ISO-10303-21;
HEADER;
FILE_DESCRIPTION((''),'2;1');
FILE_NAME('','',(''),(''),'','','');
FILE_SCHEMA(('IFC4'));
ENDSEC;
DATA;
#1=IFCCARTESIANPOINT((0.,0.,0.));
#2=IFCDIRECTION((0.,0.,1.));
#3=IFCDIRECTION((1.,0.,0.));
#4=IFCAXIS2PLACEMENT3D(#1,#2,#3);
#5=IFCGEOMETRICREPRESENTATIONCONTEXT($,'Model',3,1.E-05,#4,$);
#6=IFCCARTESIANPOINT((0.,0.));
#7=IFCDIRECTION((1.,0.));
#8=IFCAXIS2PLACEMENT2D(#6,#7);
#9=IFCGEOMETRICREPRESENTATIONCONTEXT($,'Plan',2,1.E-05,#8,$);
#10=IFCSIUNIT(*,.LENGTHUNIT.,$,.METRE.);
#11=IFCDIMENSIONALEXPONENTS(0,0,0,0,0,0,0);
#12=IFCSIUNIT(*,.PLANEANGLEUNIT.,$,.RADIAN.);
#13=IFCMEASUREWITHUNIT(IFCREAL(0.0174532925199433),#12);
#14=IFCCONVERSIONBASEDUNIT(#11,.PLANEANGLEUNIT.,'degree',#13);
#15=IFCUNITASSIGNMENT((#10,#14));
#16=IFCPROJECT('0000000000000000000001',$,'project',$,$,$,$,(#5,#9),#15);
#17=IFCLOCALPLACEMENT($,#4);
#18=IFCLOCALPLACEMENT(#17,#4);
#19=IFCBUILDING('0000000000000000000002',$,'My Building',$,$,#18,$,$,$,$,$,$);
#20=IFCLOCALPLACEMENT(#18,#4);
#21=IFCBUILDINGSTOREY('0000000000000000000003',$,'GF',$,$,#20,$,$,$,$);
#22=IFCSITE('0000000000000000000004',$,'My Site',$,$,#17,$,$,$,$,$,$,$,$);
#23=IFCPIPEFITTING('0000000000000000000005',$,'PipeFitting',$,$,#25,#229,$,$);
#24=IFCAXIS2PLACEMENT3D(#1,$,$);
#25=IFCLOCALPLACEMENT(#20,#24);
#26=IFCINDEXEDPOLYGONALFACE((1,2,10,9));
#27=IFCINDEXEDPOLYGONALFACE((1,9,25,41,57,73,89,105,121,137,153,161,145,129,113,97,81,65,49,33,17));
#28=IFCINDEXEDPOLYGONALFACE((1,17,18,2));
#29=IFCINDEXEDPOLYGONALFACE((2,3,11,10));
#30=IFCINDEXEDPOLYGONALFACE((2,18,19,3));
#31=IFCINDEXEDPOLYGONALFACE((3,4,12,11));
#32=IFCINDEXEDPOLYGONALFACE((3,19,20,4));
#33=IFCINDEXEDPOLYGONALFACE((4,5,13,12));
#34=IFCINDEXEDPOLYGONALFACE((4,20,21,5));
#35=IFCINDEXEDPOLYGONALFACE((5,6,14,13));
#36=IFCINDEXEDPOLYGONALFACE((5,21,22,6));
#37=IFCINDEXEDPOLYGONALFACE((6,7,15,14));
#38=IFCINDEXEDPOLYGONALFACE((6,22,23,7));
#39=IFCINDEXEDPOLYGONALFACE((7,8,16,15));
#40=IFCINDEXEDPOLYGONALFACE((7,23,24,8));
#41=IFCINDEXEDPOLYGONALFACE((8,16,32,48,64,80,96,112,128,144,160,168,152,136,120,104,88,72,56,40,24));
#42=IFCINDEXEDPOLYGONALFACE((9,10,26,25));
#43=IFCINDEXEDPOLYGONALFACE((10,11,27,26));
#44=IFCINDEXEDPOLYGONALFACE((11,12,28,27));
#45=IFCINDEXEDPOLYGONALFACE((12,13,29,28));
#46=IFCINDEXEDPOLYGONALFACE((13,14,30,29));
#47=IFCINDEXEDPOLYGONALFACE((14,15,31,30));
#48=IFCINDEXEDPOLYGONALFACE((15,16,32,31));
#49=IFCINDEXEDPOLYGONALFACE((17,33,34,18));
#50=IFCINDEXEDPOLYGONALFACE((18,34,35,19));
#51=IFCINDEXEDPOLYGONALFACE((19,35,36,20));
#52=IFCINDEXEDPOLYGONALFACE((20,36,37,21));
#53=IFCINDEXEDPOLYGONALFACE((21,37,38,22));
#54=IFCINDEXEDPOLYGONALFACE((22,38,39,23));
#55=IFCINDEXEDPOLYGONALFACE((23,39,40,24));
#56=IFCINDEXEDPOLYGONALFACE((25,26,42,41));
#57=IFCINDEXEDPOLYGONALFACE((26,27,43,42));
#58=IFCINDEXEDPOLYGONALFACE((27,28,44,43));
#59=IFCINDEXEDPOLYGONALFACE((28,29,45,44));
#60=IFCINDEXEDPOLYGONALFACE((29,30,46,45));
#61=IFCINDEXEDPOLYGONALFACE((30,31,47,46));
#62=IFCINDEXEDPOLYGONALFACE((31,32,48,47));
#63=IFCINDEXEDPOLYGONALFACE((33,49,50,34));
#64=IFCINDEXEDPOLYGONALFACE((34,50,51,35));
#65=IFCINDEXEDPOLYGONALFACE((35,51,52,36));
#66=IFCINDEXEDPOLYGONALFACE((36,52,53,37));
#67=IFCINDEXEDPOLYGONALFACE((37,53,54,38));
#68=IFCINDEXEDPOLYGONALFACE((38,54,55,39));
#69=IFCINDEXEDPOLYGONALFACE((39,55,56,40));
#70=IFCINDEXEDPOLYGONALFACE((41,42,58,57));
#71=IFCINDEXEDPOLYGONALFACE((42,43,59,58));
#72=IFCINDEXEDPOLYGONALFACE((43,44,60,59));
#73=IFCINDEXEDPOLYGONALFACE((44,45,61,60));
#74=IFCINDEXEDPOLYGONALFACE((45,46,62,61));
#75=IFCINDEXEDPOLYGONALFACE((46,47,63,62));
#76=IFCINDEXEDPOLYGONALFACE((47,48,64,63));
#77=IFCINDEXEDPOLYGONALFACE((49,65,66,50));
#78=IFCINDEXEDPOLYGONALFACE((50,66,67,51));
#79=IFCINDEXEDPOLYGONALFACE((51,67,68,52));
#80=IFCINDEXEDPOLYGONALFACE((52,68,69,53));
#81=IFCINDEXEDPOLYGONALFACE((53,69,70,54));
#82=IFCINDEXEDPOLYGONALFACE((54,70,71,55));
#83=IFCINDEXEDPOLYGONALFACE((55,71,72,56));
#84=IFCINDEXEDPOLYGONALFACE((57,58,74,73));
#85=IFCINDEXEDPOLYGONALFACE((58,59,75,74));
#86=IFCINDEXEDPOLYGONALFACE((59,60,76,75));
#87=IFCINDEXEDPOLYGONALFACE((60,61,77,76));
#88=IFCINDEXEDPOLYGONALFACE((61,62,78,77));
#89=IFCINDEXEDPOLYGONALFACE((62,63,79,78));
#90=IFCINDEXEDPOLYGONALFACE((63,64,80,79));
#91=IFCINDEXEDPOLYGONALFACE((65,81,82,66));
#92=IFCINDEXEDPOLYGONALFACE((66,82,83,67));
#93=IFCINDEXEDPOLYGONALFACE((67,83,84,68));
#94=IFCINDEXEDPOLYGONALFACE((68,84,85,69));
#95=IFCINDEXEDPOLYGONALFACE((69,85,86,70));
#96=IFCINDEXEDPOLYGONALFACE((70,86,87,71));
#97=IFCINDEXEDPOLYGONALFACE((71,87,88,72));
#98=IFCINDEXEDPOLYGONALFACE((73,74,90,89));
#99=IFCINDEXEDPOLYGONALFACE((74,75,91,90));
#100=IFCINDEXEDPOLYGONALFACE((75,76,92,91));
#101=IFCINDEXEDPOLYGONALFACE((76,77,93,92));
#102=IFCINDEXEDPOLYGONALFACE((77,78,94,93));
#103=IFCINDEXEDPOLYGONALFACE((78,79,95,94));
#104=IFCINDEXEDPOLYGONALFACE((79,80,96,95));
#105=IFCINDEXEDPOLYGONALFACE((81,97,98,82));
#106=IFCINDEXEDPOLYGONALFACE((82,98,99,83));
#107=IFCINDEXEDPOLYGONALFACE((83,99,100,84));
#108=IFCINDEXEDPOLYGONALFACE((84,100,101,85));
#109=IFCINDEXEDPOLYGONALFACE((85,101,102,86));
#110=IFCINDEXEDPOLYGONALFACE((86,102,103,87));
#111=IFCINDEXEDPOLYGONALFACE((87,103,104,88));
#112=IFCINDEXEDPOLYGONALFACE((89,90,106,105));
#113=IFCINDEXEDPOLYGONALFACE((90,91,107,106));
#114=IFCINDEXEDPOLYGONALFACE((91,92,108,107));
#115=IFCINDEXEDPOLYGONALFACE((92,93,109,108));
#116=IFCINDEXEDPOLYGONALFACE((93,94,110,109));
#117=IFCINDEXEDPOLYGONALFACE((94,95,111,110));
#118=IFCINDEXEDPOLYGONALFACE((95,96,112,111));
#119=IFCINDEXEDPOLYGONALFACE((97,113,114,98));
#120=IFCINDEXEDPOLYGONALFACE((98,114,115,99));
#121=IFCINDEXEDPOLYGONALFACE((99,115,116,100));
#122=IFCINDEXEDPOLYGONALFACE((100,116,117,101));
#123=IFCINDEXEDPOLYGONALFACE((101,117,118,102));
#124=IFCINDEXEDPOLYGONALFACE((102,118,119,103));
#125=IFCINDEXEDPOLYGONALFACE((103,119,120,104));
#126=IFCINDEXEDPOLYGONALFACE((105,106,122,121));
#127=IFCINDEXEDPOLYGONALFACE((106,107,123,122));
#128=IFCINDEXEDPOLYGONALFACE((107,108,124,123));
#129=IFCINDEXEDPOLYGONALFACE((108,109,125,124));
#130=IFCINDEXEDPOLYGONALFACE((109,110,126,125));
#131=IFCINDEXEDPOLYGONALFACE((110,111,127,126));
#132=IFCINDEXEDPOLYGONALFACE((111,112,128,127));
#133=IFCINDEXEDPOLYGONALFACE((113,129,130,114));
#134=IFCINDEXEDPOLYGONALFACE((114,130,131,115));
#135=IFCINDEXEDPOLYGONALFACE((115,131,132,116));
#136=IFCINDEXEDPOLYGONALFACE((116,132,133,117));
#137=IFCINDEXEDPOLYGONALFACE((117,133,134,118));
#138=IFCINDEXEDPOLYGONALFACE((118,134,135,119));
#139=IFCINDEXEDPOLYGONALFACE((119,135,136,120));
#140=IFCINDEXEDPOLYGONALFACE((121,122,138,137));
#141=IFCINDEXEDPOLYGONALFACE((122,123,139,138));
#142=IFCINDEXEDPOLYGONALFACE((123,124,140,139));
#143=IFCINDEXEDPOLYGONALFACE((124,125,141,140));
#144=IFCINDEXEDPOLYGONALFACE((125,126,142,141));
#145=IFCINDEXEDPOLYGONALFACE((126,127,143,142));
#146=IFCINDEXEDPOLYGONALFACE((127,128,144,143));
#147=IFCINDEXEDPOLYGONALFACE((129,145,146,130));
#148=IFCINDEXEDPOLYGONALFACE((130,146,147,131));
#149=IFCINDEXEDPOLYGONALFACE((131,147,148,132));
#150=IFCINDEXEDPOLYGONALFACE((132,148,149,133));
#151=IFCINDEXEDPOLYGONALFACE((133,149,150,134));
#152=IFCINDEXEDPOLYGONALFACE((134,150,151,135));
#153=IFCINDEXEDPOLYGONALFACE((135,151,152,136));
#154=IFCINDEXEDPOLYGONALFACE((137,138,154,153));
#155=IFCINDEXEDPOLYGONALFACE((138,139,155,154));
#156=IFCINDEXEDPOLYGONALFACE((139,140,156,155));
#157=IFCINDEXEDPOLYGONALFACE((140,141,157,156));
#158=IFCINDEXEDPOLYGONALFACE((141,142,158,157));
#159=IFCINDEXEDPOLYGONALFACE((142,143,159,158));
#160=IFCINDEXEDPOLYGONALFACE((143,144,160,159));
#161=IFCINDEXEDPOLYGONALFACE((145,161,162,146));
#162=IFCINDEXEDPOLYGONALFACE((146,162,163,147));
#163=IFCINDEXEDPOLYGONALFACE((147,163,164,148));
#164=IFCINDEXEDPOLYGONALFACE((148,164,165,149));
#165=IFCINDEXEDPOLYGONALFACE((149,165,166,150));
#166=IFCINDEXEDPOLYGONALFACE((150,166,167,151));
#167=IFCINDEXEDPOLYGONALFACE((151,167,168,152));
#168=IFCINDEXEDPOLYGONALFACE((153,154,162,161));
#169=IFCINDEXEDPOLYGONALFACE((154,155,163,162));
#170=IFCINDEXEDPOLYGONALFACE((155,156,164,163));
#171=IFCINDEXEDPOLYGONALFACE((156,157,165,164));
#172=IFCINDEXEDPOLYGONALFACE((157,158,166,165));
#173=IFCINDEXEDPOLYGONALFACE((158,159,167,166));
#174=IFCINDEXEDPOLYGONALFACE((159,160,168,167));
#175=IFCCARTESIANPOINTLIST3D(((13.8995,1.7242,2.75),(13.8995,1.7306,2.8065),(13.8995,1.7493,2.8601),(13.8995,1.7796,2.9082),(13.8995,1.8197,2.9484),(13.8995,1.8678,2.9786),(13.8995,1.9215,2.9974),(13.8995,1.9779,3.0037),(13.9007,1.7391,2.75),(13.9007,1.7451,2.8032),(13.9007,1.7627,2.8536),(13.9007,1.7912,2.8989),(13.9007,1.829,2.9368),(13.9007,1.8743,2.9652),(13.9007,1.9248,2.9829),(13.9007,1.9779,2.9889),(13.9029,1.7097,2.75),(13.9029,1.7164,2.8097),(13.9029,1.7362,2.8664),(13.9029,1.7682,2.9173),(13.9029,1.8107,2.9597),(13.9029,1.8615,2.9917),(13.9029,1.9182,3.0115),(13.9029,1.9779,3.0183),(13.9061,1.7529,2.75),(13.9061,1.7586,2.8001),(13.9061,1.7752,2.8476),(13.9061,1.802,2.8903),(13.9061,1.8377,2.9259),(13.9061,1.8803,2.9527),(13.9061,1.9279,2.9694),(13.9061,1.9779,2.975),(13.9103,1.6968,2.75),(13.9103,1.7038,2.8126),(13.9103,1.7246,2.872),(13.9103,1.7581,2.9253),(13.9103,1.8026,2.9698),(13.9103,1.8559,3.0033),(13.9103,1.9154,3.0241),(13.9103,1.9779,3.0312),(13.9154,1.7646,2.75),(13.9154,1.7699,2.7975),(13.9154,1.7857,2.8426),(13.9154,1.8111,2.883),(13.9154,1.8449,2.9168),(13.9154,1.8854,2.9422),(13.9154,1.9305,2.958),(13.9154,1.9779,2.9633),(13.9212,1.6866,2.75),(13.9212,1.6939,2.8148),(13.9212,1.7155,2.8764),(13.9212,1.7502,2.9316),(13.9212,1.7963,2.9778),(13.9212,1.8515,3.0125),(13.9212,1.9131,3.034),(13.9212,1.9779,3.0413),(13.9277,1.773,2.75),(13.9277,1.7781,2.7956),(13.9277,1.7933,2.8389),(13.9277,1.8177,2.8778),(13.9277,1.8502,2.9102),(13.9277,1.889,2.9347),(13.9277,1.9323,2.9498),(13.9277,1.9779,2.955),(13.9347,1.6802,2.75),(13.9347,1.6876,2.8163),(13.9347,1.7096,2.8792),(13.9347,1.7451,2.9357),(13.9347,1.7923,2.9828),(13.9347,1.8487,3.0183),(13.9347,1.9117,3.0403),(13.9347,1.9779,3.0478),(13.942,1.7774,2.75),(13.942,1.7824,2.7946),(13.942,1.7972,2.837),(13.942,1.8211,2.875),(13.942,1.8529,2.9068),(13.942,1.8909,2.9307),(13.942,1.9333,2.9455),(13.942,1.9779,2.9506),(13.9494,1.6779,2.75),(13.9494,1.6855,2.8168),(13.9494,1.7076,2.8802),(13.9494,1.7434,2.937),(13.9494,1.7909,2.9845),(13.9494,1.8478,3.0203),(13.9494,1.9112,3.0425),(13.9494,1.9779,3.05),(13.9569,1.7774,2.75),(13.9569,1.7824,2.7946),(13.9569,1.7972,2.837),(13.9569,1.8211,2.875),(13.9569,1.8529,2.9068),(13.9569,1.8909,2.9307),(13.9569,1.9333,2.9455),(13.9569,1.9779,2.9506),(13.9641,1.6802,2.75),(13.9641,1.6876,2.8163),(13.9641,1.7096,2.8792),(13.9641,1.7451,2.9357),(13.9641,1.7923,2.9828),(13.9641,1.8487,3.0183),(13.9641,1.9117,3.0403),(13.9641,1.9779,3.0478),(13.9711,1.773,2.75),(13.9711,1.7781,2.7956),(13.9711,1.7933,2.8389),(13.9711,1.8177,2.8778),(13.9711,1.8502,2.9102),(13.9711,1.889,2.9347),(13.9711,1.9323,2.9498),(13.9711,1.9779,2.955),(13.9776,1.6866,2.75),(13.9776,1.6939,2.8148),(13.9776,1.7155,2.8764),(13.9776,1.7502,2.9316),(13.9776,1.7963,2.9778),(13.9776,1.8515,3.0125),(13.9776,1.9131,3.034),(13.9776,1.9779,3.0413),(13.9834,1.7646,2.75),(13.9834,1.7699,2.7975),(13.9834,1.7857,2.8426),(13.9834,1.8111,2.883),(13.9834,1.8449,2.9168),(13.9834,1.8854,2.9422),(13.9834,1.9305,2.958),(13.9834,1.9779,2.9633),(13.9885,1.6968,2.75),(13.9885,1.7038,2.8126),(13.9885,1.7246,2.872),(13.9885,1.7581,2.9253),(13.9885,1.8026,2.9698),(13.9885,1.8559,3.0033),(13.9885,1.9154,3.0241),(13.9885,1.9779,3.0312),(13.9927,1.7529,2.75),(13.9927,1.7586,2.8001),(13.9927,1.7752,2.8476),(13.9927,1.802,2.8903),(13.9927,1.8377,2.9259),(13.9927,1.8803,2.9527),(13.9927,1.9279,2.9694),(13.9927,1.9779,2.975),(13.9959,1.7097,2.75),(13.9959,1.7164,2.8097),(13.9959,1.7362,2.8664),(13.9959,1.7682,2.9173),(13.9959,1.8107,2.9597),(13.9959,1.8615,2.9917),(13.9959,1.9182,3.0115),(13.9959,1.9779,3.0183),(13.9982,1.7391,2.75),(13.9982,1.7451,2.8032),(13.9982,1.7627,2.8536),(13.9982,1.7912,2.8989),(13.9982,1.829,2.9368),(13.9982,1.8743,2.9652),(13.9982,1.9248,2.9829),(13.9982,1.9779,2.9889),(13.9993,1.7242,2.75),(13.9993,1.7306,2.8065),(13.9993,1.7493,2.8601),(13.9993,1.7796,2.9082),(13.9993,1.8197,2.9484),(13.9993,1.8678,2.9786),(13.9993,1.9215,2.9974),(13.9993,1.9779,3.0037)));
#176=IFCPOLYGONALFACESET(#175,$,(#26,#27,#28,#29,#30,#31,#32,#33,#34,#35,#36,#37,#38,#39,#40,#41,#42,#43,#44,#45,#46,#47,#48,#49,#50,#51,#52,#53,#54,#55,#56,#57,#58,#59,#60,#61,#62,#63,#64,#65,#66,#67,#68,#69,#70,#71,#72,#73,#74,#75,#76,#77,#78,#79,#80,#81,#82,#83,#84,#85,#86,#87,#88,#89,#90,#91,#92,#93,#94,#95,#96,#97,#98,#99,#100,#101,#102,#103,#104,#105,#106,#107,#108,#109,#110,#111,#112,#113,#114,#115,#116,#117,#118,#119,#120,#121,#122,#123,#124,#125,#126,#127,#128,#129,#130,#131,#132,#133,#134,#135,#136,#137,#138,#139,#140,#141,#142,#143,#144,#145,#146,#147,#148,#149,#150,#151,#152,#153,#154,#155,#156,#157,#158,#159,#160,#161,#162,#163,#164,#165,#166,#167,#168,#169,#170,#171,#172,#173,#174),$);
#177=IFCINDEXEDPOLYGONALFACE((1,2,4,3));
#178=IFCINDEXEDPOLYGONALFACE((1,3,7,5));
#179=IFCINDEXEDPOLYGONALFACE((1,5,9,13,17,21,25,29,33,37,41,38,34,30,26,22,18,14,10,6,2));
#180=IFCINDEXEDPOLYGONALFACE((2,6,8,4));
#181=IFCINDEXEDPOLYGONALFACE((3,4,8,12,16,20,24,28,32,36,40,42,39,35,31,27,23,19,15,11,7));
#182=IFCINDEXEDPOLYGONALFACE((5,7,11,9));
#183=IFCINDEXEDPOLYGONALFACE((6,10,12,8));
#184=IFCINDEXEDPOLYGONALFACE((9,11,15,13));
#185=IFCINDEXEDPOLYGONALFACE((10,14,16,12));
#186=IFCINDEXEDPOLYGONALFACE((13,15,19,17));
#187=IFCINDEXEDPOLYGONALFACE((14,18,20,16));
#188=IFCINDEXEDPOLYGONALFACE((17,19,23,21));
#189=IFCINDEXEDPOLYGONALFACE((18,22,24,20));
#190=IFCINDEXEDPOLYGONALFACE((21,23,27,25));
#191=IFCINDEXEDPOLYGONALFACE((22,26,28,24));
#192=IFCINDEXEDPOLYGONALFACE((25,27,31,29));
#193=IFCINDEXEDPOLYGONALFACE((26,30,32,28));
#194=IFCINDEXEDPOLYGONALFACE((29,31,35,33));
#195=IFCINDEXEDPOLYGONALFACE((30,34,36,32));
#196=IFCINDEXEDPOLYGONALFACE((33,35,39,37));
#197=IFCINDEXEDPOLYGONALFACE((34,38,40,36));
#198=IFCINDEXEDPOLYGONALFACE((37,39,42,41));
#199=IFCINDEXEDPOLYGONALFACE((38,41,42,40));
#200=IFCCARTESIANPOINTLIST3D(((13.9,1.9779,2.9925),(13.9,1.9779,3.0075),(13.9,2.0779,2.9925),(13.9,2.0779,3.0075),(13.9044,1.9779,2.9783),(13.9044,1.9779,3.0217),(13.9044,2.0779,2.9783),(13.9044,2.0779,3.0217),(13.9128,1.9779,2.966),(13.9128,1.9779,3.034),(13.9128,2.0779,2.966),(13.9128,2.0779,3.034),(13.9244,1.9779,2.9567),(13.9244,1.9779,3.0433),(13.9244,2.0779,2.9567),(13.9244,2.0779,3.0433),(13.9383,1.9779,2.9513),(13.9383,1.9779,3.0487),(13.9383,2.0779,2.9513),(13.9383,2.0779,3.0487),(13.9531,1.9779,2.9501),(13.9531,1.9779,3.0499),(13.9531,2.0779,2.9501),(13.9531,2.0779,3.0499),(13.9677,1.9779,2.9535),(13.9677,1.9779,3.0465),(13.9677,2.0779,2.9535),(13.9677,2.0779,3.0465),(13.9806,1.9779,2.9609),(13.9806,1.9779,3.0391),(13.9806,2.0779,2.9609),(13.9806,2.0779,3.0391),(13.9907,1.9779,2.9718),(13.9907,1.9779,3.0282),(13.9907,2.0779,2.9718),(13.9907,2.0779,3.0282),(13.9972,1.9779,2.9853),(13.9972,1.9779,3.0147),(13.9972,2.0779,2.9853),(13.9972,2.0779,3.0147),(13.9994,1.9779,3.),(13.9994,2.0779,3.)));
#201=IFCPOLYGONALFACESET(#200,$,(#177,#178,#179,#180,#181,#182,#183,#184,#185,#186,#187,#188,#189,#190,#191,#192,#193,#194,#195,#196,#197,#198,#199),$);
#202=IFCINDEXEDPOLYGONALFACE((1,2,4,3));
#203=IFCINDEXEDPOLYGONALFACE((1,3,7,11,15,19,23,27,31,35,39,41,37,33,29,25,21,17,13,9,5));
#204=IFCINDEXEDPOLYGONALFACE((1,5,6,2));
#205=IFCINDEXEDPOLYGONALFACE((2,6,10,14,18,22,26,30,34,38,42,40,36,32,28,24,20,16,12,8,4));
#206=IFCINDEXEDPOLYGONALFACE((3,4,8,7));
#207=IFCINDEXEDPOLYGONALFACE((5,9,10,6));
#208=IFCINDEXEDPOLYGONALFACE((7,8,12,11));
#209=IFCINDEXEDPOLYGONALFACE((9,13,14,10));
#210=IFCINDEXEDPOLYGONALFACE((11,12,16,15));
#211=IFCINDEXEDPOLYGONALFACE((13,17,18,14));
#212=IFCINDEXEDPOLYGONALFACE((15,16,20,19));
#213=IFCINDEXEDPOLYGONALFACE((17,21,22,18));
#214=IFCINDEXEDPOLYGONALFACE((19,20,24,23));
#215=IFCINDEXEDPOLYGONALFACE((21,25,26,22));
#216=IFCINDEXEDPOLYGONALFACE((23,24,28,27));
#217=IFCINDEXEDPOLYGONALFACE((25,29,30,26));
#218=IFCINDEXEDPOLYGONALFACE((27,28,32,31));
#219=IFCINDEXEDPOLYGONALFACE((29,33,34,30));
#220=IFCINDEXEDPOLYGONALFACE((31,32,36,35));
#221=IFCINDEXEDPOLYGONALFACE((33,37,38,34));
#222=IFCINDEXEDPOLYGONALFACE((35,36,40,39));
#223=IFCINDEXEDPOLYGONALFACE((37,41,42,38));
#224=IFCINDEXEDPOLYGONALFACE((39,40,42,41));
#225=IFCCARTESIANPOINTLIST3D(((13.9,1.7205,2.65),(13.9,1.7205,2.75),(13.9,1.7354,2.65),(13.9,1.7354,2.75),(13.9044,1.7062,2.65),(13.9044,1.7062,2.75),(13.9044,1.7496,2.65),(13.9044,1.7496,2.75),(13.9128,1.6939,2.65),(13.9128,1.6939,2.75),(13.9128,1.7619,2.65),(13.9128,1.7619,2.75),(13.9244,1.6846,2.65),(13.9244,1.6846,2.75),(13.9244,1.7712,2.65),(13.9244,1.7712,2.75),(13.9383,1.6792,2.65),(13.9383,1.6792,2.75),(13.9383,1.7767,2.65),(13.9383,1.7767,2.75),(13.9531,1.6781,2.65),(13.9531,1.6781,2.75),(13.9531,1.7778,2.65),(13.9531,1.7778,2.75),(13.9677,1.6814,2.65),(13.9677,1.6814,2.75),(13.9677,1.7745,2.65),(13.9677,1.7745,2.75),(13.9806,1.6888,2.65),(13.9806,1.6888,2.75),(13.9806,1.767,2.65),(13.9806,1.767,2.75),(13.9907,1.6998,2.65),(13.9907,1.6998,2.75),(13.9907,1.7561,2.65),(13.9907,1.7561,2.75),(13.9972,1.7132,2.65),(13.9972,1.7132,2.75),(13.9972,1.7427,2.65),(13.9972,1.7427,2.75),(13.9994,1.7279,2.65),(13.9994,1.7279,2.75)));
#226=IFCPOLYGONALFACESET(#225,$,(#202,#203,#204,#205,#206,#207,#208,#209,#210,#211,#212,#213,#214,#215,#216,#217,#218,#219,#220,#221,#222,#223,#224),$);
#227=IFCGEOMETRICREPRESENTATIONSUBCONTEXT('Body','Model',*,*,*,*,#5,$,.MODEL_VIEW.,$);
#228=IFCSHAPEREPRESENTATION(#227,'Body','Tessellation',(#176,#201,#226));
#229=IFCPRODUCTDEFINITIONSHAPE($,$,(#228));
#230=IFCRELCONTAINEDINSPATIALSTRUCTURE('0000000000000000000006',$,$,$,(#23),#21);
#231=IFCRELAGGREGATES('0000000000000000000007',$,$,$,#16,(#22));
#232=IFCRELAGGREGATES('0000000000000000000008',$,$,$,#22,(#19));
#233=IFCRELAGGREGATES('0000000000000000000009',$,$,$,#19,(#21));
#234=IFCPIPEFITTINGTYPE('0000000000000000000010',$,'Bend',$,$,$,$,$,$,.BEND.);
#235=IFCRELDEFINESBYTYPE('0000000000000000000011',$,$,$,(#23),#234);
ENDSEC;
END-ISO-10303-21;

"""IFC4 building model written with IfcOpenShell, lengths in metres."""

from ifc_helpers import new_model, entity, si_unit, converted_unit, frame, origin_with_axes, origin_2d_with_axis, place, context, subcontext, project, spatial, circle, extrude, source, transform, mapped, type_object, type_shapes, element, save


model = new_model("IFC4")

# Units and contexts
model_context = context("Model", 3, precision=1e-05, world=origin_with_axes())
plan_context = context("Plan", 2, precision=1e-05, world=origin_2d_with_axis())
body_context = subcontext(model_context, "Body", "Model", "MODEL_VIEW")
ifc_project = project(units=[si_unit("LENGTHUNIT", "METRE"), converted_unit("PLANEANGLEUNIT", "degree", entity("IfcReal", 0.0174532925199433), si_unit("PLANEANGLEUNIT", "RADIAN"), dimensions=[0, 0, 0, 0, 0, 0, 0])], contexts=[model_context, plan_context])

# Site, building, storey
site_placement = place(None, origin_with_axes())
site = spatial("IfcSite", under=ifc_project, at=site_placement, Name="My Site")
building_placement = place(site_placement, origin_with_axes())
building = spatial("IfcBuilding", under=site, at=building_placement, Name="My Building")
storey_placement = place(building_placement, origin_with_axes())
storey = spatial("IfcBuildingStorey", under=building, at=storey_placement, Name="GF")

# Pipe fitting
pipe_fitting_type = type_object("IfcPipeFittingType", Name="Bend", PredefinedType="BEND")
shared_shape = source(origin_with_axes(), body_context, "Body", "SolidModel", [
    entity("IfcSweptDiskSolid", entity("IfcIndexedPolyCurve", entity("IfcCartesianPointList3D", [[0.0, 0.0, 0.1], [0.0, -0.0732, 0.2768], [0.0, -0.25, 0.35]]), [entity("IfcArcIndex", [1, 2, 3])]), 0.05),
    extrude(circle(Radius=0.05), origin_with_axes(), (0.0, 0.0, 1.0), 0.1),
    extrude(circle(Radius=0.05), frame((0.0, -0.25, 0.35), z_axis=(0.0, -1.0, 0.0), x_axis=(1.0, 0.0, 0.0)), (0.0, 0.0, 1.0), 0.1),
])
type_shapes(pipe_fitting_type, [shared_shape])
for number, where, z_axis, x_axis, name in (
    (1, (13.9494, 2.0779, 3.0), (0.0, -1.0, 0.0), (1.0, 0.0, 0.0), "PipeFitting"),
):
    element("IfcPipeFitting", number, at=place(storey_placement, frame(where, z_axis=z_axis, x_axis=x_axis)), inside=storey, type_object=pipe_fitting_type, Name=name, context=body_context, shape_type="MappedRepresentation", body=[
        mapped(shared_shape, transform((0.0, 0.0, 0.0), x_axis=(1.0, 0.0, 0.0), y_axis=(0.0, 1.0, 0.0), z_axis=(0.0, 0.0, 1.0), scale=1.0)),
    ])

save(model, "model.ifc")
